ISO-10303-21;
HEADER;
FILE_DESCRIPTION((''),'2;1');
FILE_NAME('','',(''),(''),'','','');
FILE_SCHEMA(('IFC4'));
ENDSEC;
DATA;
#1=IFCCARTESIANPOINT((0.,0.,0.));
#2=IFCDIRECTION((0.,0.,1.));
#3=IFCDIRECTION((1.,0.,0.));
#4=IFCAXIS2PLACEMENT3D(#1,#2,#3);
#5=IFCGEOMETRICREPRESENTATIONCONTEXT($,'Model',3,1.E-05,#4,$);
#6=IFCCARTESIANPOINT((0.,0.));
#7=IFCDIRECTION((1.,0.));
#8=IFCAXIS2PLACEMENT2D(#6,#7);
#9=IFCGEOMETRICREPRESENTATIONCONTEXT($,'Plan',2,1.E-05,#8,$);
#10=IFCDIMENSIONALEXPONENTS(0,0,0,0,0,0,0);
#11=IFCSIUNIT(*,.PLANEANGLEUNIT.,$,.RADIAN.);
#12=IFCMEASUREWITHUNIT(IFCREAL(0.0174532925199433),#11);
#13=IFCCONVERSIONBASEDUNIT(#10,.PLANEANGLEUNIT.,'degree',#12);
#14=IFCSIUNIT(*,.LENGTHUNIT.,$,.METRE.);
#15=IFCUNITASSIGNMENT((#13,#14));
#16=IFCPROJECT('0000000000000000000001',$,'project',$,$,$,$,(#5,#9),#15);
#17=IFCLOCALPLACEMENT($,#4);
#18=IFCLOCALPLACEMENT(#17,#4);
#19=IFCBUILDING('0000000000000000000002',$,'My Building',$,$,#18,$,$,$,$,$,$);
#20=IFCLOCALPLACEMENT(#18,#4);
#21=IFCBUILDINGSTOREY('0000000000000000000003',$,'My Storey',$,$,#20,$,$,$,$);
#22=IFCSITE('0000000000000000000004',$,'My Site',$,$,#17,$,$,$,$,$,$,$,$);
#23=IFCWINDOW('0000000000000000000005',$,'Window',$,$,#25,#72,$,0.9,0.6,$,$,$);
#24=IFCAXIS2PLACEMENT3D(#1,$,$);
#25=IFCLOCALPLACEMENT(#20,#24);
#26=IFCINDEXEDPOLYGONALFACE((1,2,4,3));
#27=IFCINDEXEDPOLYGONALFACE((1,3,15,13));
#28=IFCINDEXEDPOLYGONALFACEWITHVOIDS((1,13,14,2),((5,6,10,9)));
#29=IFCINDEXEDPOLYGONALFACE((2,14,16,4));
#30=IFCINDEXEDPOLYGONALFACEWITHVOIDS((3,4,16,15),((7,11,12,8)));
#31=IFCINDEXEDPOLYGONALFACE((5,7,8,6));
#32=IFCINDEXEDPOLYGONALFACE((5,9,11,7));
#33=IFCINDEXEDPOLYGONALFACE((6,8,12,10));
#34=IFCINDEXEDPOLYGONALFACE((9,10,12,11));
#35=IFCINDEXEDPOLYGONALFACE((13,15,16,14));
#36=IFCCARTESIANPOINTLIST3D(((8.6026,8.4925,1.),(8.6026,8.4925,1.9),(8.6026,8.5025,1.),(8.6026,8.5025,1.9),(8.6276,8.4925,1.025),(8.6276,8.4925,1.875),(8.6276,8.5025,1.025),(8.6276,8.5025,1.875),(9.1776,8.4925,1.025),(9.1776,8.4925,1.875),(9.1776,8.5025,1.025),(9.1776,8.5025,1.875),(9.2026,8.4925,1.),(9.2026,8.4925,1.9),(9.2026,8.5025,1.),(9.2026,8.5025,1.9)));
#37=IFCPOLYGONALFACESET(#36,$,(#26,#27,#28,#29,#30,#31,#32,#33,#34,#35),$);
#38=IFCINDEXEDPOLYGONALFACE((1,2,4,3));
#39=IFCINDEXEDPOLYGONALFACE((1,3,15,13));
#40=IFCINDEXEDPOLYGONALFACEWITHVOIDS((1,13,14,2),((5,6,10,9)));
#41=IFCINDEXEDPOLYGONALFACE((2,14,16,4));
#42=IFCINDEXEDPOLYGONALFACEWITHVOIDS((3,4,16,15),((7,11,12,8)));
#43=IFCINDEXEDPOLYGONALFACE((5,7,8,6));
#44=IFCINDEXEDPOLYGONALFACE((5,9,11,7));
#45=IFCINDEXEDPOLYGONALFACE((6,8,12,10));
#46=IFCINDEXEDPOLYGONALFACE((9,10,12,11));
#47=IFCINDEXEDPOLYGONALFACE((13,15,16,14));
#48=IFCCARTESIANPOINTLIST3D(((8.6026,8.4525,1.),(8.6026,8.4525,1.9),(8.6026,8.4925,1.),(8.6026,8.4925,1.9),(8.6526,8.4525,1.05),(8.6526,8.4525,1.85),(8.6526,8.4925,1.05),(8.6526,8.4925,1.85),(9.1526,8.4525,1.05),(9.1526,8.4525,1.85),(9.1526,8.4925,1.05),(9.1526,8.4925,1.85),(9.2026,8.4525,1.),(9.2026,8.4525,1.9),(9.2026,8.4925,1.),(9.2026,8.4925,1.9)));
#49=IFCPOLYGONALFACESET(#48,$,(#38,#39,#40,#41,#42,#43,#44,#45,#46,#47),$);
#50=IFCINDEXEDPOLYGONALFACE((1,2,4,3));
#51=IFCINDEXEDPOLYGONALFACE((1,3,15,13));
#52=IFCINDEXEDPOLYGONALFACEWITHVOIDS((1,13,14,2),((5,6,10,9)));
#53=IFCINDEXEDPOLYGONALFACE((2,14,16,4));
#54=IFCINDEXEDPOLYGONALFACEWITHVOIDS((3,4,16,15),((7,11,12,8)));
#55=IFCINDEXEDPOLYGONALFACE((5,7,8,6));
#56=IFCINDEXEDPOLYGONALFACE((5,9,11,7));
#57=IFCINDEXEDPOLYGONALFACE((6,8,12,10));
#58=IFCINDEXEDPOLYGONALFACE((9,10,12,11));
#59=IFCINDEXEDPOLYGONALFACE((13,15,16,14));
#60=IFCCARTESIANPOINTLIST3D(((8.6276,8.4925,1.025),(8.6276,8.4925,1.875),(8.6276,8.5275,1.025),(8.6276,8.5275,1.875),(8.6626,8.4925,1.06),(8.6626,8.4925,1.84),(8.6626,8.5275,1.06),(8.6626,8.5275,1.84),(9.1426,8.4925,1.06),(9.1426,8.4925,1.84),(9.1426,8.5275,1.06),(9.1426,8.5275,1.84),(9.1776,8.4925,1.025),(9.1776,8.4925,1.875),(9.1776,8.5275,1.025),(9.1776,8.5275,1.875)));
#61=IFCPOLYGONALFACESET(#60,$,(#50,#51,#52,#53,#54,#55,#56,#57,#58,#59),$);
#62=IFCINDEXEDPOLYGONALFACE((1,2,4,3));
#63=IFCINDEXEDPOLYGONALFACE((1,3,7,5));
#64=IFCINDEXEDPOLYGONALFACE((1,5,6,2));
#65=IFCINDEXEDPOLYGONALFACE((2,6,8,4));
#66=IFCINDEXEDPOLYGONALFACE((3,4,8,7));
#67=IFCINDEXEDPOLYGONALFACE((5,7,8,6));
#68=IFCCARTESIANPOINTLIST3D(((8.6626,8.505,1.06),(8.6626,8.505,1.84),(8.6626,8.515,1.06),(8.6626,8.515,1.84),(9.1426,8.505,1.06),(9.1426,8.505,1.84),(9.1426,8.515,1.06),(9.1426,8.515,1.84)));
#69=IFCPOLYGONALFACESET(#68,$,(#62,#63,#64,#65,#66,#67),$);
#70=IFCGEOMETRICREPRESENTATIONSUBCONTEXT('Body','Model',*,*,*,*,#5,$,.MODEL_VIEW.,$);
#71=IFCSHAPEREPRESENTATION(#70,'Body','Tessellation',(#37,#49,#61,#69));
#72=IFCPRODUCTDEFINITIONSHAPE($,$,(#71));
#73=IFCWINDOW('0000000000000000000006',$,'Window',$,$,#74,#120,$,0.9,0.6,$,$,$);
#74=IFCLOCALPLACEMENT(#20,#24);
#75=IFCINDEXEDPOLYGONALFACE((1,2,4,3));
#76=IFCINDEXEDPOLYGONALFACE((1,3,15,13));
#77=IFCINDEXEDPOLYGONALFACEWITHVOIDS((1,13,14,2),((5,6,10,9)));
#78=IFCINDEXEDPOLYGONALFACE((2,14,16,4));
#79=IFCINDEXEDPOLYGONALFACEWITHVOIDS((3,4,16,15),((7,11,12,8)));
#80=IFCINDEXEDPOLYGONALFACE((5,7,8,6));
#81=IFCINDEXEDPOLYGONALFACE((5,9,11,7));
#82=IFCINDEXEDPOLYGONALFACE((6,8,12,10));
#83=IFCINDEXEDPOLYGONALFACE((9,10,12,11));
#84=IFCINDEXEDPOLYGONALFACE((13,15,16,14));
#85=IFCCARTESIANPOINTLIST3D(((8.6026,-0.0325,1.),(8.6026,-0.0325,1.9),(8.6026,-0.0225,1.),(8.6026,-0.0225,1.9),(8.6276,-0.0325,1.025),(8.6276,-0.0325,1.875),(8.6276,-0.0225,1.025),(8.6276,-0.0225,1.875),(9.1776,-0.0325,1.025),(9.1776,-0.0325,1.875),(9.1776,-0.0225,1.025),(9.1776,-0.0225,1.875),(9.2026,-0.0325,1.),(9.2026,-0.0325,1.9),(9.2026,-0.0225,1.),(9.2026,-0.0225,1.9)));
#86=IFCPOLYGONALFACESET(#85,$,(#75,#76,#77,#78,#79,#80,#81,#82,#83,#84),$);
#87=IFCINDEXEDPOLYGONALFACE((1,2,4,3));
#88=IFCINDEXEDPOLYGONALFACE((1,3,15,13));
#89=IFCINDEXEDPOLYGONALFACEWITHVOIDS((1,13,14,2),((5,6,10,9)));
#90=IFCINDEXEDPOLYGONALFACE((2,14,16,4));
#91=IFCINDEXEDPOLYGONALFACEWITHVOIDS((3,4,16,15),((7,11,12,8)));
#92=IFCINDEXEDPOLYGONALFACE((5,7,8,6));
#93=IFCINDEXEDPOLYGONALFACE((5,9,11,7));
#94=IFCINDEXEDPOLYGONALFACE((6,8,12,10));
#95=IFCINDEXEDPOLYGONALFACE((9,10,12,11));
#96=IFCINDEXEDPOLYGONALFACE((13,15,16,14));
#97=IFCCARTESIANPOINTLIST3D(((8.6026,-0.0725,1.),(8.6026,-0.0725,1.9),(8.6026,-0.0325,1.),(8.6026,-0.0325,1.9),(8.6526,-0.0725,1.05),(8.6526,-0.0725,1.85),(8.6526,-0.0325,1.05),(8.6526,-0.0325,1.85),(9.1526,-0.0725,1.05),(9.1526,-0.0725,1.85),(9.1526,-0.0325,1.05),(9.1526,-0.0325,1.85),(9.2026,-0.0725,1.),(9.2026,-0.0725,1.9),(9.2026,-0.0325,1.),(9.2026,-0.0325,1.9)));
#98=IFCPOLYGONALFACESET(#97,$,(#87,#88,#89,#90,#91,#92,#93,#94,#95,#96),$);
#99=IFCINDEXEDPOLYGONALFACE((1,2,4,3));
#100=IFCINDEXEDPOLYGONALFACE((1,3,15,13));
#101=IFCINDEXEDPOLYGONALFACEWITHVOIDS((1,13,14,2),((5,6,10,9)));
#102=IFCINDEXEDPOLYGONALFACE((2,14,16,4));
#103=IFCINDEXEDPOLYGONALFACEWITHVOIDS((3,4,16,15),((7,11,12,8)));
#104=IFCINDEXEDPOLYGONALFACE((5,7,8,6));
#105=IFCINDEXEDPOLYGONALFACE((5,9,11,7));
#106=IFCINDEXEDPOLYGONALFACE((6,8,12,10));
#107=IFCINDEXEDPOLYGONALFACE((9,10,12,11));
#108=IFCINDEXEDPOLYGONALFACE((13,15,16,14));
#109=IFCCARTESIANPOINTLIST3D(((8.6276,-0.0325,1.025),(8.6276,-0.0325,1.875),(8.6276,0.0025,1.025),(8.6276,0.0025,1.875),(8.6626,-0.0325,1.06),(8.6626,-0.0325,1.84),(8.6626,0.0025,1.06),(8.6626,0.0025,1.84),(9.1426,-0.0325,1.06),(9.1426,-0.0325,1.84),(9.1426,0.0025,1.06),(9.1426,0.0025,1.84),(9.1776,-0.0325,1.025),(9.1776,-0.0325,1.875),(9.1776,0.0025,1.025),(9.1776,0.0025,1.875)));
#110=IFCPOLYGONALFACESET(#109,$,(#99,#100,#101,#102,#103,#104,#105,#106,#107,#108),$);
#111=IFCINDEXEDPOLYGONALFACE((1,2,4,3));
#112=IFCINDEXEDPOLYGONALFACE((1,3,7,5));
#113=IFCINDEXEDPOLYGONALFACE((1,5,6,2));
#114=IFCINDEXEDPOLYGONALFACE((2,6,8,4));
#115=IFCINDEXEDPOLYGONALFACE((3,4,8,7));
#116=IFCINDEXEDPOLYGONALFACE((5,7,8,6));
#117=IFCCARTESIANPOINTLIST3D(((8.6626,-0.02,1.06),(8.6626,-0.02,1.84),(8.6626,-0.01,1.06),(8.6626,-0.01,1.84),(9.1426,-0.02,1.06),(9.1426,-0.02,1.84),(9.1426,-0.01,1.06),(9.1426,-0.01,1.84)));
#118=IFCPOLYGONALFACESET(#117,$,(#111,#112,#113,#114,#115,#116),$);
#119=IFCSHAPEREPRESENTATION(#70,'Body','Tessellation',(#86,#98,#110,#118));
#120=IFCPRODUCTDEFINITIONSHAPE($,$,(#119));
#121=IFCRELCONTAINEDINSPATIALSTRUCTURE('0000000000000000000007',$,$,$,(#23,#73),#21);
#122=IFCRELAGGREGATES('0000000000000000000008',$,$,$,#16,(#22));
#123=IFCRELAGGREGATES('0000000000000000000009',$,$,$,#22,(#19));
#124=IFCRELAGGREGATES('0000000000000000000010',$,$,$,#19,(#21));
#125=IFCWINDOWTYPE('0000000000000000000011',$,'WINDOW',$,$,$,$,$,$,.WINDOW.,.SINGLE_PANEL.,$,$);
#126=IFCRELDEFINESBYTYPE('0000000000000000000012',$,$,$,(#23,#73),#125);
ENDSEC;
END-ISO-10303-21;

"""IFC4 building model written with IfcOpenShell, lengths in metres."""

from ifc_helpers import new_model, entity, si_unit, converted_unit, frame, origin_with_axes, origin_2d_with_axis, place, context, subcontext, project, spatial, line, indexed_curve, outline, extrude, shape, source, transform, mapped, type_object, type_shapes, element, save


model = new_model("IFC4")

# Units and contexts
model_context = context("Model", 3, precision=1e-05, world=origin_with_axes())
plan_context = context("Plan", 2, precision=1e-05, world=origin_2d_with_axis())
body_context_1 = subcontext(model_context, "Body", "Model", "MODEL_VIEW")
body_context_2 = subcontext(plan_context, "Body", "Plan", "PLAN_VIEW")
ifc_project = project(units=[converted_unit("PLANEANGLEUNIT", "degree", entity("IfcReal", 0.0174532925199433), si_unit("PLANEANGLEUNIT", "RADIAN"), dimensions=[0, 0, 0, 0, 0, 0, 0]), si_unit("LENGTHUNIT", "METRE")], contexts=[model_context, plan_context])

# Site, building, storey
site_placement = place(None, origin_with_axes())
site = spatial("IfcSite", under=ifc_project, at=site_placement, Name="My Site")
building_placement = place(site_placement, origin_with_axes())
building = spatial("IfcBuilding", under=site, at=building_placement, Name="My Building")
storey_placement = place(building_placement, origin_with_axes())
storey = spatial("IfcBuildingStorey", under=building, at=storey_placement, Name="My Storey")

# Shared definitions
window_type = type_object("IfcWindowType", Name="WINDOW", PartitioningType="SINGLE_PANEL", PredefinedType="WINDOW")
shared_shape_1 = source(origin_with_axes(), body_context_1, "Body", "SweptSolid", [
    extrude(outline(indexed_curve([(0.0, 0.0), (0.6, 0.0), (0.6, 0.9), (0.0, 0.9)], segments=[line(1, 2, 3, 4, 1)]), holes=[indexed_curve([(0.025, 0.025), (0.575, 0.025), (0.575, 0.875), (0.025, 0.875)], segments=[line(1, 2, 3, 4, 1)])]), frame((0.0, 0.09, 0.0), z_axis=(0.0, -1.0, 0.0), x_axis=(1.0, 0.0, 0.0)), (0.0, 0.0, -1.0), 0.01),
    extrude(outline(indexed_curve([(0.0, 0.0), (0.6, 0.0), (0.6, 0.9), (0.0, 0.9)], segments=[line(1, 2, 3, 4, 1)]), holes=[indexed_curve([(0.05, 0.05), (0.55, 0.05), (0.55, 0.85), (0.05, 0.85)], segments=[line(1, 2, 3, 4, 1)])]), frame((0.0, 0.05, 0.0), z_axis=(0.0, -1.0, 0.0), x_axis=(1.0, 0.0, 0.0)), (0.0, 0.0, -1.0), 0.04),
    extrude(outline(indexed_curve([(0.0, 0.0), (0.55, 0.0), (0.55, 0.85), (0.0, 0.85)], segments=[line(1, 2, 3, 4, 1)]), holes=[indexed_curve([(0.035, 0.035), (0.515, 0.035), (0.515, 0.815), (0.035, 0.815)], segments=[line(1, 2, 3, 4, 1)])]), frame((0.025, 0.09, 0.025), z_axis=(0.0, -1.0, 0.0), x_axis=(1.0, 0.0, 0.0)), (0.0, 0.0, -1.0), 0.035),
    extrude(outline(indexed_curve([(0.035, 0.035), (0.515, 0.035), (0.515, 0.815), (0.035, 0.815)], segments=[line(1, 2, 3, 4, 1)])), frame((0.025, 0.1025, 0.025), z_axis=(0.0, -1.0, 0.0), x_axis=(1.0, 0.0, 0.0)), (0.0, 0.0, -1.0), 0.01),
])
shared_shape_2 = source(origin_with_axes(), body_context_2, "Body", "Curve2D", [
    entity("IfcIndexedPolyCurve", entity("IfcCartesianPointList2D", [[0.05, 0.05], [0.55, 0.05]])),
    entity("IfcIndexedPolyCurve", entity("IfcCartesianPointList2D", [[0.0, 0.1], [0.025, 0.1], [0.025, 0.09], [0.05, 0.09], [0.05, 0.05], [0.0, 0.05]]), [entity("IfcLineIndex", [1, 2, 3, 4, 5, 6, 1])]),
    entity("IfcIndexedPolyCurve", entity("IfcCartesianPointList2D", [[0.6, 0.1], [0.575, 0.1], [0.575, 0.09], [0.55, 0.09], [0.55, 0.05], [0.6, 0.05]]), [entity("IfcLineIndex", [1, 2, 3, 4, 5, 6, 1])]),
    entity("IfcIndexedPolyCurve", entity("IfcCartesianPointList2D", [[0.025, 0.09], [0.06, 0.09], [0.06, 0.125], [0.025, 0.125]]), [entity("IfcLineIndex", [1, 2, 3, 4, 1])]),
    entity("IfcIndexedPolyCurve", entity("IfcCartesianPointList2D", [[0.575, 0.09], [0.54, 0.09], [0.54, 0.125], [0.575, 0.125]]), [entity("IfcLineIndex", [1, 2, 3, 4, 1])]),
    entity("IfcIndexedPolyCurve", entity("IfcCartesianPointList2D", [[0.06, 0.09], [0.54, 0.09]])),
    entity("IfcIndexedPolyCurve", entity("IfcCartesianPointList2D", [[0.06, 0.125], [0.54, 0.125]])),
    entity("IfcIndexedPolyCurve", entity("IfcCartesianPointList2D", [[0.06, 0.1075], [0.54, 0.1075]])),
])
type_shapes(window_type, [shared_shape_1, shared_shape_2])

# Windows
placement_1 = place(storey_placement, frame((1.0202, 8.4025, 0.0), z_axis=(0.0, 0.0, 1.0), x_axis=(1.0, 0.0, 0.0)))
placement_2 = place(placement_1, frame((7.5824, 0.0, 1.0), z_axis=(0.0, 0.0, 1.0), x_axis=(1.0, 0.0, 0.0)))
window_1_placement = place(placement_2, origin_with_axes())
element("IfcWindow", 1, at=window_1_placement, inside=storey, type_object=window_type, Name="Window", OverallHeight=0.9, OverallWidth=0.6, shapes=[
    shape(body_context_1, "Body", "MappedRepresentation", [mapped(shared_shape_1, transform((0.0, 0.0, 0.0), x_axis=(1.0, 0.0, 0.0), y_axis=(0.0, 1.0, 0.0), z_axis=(0.0, 0.0, 1.0), scale=1.0))]),
    shape(body_context_2, "Body", "MappedRepresentation", [mapped(shared_shape_2, transform((0.0, 0.0, 0.0), x_axis=(1.0, 0.0, 0.0), y_axis=(0.0, 1.0, 0.0), z_axis=(0.0, 0.0, 1.0), scale=1.0))]),
])
window_2_placement = place(storey_placement, frame((8.6026, -0.1225, 1.0), z_axis=(0.0, 0.0, 1.0), x_axis=(1.0, 0.0, 0.0)))
element("IfcWindow", 2, at=window_2_placement, inside=storey, type_object=window_type, Name="Window", OverallHeight=0.9, OverallWidth=0.6, shapes=[
    shape(body_context_1, "Body", "MappedRepresentation", [mapped(shared_shape_1, transform((0.0, 0.0, 0.0), x_axis=(1.0, 0.0, 0.0), y_axis=(0.0, 1.0, 0.0), z_axis=(0.0, 0.0, 1.0), scale=1.0))]),
    shape(body_context_2, "Body", "MappedRepresentation", [mapped(shared_shape_2, transform((0.0, 0.0, 0.0), x_axis=(1.0, 0.0, 0.0), y_axis=(0.0, 1.0, 0.0), z_axis=(0.0, 0.0, 1.0), scale=1.0))]),
])

save(model, "model.ifc")
